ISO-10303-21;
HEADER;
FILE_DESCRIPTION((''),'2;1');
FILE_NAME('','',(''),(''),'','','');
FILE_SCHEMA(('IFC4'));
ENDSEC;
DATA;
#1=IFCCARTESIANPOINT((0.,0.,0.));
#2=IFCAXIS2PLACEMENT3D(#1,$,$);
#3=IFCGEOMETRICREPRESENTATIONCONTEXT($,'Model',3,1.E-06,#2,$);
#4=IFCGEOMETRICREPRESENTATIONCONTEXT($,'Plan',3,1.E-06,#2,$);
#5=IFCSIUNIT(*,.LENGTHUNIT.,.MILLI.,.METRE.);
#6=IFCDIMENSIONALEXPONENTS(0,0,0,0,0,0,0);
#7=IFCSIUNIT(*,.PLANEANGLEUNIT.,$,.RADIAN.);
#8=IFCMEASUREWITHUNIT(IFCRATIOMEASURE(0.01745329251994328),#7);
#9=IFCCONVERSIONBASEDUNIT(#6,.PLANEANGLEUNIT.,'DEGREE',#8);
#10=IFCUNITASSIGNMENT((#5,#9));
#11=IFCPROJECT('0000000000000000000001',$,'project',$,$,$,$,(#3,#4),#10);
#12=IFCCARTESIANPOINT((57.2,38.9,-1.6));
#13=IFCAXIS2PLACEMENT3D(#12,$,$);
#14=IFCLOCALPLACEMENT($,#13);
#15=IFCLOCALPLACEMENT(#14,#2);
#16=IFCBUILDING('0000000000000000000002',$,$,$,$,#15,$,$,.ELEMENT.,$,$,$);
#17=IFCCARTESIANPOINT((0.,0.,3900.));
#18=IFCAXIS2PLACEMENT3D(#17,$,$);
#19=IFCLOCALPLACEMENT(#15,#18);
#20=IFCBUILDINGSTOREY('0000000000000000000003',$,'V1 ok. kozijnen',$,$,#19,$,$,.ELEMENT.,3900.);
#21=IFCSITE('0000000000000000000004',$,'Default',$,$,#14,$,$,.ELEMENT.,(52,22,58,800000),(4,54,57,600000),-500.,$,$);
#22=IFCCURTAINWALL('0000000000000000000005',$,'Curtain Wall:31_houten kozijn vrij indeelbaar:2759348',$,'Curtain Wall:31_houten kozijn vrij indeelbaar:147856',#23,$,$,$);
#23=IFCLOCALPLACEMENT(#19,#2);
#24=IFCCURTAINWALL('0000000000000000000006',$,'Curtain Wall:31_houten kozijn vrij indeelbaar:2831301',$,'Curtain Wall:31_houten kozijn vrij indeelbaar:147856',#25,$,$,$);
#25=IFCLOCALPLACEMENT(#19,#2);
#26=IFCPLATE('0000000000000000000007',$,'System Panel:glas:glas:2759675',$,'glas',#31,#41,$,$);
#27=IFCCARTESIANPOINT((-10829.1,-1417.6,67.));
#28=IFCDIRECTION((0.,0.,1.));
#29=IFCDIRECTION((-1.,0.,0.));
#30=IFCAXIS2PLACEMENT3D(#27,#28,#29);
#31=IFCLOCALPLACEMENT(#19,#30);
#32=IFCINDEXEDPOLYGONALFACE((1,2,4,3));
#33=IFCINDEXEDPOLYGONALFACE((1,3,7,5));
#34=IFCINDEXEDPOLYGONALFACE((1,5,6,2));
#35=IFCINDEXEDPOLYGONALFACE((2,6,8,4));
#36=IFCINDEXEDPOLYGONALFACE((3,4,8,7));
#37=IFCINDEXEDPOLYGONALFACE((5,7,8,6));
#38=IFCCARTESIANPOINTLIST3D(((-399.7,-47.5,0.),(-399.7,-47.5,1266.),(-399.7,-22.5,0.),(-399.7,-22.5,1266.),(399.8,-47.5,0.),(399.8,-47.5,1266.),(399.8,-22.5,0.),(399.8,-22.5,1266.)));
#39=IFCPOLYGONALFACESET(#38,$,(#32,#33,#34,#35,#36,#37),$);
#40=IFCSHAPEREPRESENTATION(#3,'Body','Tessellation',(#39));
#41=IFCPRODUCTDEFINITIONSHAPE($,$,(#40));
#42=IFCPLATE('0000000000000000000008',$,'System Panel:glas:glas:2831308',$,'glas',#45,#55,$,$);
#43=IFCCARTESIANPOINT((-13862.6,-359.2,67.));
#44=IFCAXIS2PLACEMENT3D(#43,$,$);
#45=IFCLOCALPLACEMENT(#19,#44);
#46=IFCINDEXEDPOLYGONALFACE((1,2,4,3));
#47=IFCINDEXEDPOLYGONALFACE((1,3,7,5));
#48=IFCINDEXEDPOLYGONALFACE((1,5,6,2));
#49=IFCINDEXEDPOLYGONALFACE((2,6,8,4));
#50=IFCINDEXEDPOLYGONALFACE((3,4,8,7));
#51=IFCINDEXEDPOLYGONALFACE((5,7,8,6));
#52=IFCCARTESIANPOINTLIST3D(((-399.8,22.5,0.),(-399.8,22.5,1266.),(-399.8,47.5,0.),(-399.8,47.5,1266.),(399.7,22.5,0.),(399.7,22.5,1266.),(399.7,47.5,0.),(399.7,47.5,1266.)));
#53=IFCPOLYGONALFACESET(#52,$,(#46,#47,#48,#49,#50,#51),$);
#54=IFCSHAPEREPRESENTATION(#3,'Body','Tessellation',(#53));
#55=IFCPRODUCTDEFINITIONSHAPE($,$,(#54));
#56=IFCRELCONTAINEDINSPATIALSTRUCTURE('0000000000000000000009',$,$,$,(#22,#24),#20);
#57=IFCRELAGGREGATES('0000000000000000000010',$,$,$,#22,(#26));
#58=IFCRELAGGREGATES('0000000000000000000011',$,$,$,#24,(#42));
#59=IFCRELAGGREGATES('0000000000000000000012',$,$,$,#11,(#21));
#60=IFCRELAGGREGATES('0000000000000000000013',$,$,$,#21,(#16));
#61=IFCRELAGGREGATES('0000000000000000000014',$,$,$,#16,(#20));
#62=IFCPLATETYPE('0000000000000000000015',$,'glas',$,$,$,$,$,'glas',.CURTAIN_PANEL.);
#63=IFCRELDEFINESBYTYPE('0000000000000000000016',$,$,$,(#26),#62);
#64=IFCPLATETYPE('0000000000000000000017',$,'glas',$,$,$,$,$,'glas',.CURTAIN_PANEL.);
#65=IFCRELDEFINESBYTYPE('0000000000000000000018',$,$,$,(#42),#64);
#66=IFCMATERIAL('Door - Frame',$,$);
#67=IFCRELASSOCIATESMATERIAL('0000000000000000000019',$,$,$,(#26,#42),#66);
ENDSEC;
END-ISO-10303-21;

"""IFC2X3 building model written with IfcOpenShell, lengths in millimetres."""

from ifc_helpers import new_model, entity, si_unit, converted_unit, frame, origin, origin_2d_with_axis, place, context, project, spatial, rectangle, extrude, source, transform, mapped, material, type_object, type_shapes, element, aggregate, save


model = new_model("IFC2X3")

# Units and contexts
model_context = context("Model", 3, precision=1e-06, world=origin())
plan_context = context("Plan", 3, precision=1e-06, world=origin())
ifc_project = project(units=[si_unit("LENGTHUNIT", "METRE", prefix="MILLI"), converted_unit("PLANEANGLEUNIT", "DEGREE", entity("IfcRatioMeasure", 0.01745329251994328), si_unit("PLANEANGLEUNIT", "RADIAN"), dimensions=[0, 0, 0, 0, 0, 0, 0])], contexts=[model_context, plan_context])

# Site, building, storey
site_placement = place(None, frame((57.2, 38.9, -1.6)))
site = spatial("IfcSite", under=ifc_project, at=site_placement, Name="Default", CompositionType="ELEMENT", RefLatitude=(52, 22, 58, 800000), RefLongitude=(4, 54, 57, 600000), RefElevation=-500.0)
building_placement = place(site_placement, origin())
building = spatial("IfcBuilding", under=site, at=building_placement, CompositionType="ELEMENT")
storey_placement = place(building_placement, frame((0.0, 0.0, 3900.0)))
storey = spatial("IfcBuildingStorey", under=building, at=storey_placement, Name="V1 ok. kozijnen", CompositionType="ELEMENT", Elevation=3900.0)

# Curtain walls
curtain_wall_1_placement = place(storey_placement, origin())
curtain_wall_1 = element("IfcCurtainWall", 1, at=curtain_wall_1_placement, inside=storey, Name="Curtain Wall:31_houten kozijn vrij indeelbaar:2759348", ObjectType="Curtain Wall:31_houten kozijn vrij indeelbaar:147856")
curtain_wall_2_placement = place(storey_placement, origin())
curtain_wall_2 = element("IfcCurtainWall", 2, at=curtain_wall_2_placement, inside=storey, Name="Curtain Wall:31_houten kozijn vrij indeelbaar:2831301", ObjectType="Curtain Wall:31_houten kozijn vrij indeelbaar:147856")

# Plates
ifc_material_1 = material(Name="Door - Frame")
plate_type_1 = type_object("IfcPlateType", Name="glas", ElementType="glas", PredefinedType="CURTAIN_PANEL")
shared_shape_1 = source(origin(), model_context, "Body", "SweptSolid", [
    extrude(rectangle(XDim=25.0, YDim=799.5, at=origin_2d_with_axis()), frame((0.0, -35.0, 0.0), z_axis=(0.0, 0.0, 1.0), x_axis=(0.0, 1.0, 0.0)), (0.0, 0.0, 1.0), 1266.0),
])
type_shapes(plate_type_1, [shared_shape_1])
plate_1_placement = place(storey_placement, frame((-10829.1, -1417.6, 67.0), z_axis=(0.0, 0.0, 1.0), x_axis=(-1.0, 0.0, 0.0)))
plate_1 = element("IfcPlate", 3, at=plate_1_placement, type_object=plate_type_1, material=ifc_material_1, Name="System Panel:glas:glas:2759675", ObjectType="glas", context=model_context, shape_type="MappedRepresentation", body=[
    mapped(shared_shape_1, transform((0.0, 0.0, 0.0), scale=1.0)),
])
aggregate(curtain_wall_1, [plate_1])
plate_type_2 = type_object("IfcPlateType", Name="glas", ElementType="glas", PredefinedType="CURTAIN_PANEL")
shared_shape_2 = source(origin(), model_context, "Body", "SweptSolid", [
    extrude(rectangle(XDim=25.0, YDim=799.5, at=origin_2d_with_axis()), frame((0.0, 35.0, 0.0), z_axis=(0.0, 0.0, 1.0), x_axis=(0.0, 1.0, 0.0)), (0.0, 0.0, 1.0), 1266.0),
])
type_shapes(plate_type_2, [shared_shape_2])
plate_2_placement = place(storey_placement, frame((-13862.6, -359.2, 67.0)))
plate_2 = element("IfcPlate", 4, at=plate_2_placement, type_object=plate_type_2, material=ifc_material_1, Name="System Panel:glas:glas:2831308", ObjectType="glas", context=model_context, shape_type="MappedRepresentation", body=[
    mapped(shared_shape_2, transform((0.0, 0.0, 0.0), scale=1.0)),
])
aggregate(curtain_wall_2, [plate_2])

save(model, "model.ifc")
